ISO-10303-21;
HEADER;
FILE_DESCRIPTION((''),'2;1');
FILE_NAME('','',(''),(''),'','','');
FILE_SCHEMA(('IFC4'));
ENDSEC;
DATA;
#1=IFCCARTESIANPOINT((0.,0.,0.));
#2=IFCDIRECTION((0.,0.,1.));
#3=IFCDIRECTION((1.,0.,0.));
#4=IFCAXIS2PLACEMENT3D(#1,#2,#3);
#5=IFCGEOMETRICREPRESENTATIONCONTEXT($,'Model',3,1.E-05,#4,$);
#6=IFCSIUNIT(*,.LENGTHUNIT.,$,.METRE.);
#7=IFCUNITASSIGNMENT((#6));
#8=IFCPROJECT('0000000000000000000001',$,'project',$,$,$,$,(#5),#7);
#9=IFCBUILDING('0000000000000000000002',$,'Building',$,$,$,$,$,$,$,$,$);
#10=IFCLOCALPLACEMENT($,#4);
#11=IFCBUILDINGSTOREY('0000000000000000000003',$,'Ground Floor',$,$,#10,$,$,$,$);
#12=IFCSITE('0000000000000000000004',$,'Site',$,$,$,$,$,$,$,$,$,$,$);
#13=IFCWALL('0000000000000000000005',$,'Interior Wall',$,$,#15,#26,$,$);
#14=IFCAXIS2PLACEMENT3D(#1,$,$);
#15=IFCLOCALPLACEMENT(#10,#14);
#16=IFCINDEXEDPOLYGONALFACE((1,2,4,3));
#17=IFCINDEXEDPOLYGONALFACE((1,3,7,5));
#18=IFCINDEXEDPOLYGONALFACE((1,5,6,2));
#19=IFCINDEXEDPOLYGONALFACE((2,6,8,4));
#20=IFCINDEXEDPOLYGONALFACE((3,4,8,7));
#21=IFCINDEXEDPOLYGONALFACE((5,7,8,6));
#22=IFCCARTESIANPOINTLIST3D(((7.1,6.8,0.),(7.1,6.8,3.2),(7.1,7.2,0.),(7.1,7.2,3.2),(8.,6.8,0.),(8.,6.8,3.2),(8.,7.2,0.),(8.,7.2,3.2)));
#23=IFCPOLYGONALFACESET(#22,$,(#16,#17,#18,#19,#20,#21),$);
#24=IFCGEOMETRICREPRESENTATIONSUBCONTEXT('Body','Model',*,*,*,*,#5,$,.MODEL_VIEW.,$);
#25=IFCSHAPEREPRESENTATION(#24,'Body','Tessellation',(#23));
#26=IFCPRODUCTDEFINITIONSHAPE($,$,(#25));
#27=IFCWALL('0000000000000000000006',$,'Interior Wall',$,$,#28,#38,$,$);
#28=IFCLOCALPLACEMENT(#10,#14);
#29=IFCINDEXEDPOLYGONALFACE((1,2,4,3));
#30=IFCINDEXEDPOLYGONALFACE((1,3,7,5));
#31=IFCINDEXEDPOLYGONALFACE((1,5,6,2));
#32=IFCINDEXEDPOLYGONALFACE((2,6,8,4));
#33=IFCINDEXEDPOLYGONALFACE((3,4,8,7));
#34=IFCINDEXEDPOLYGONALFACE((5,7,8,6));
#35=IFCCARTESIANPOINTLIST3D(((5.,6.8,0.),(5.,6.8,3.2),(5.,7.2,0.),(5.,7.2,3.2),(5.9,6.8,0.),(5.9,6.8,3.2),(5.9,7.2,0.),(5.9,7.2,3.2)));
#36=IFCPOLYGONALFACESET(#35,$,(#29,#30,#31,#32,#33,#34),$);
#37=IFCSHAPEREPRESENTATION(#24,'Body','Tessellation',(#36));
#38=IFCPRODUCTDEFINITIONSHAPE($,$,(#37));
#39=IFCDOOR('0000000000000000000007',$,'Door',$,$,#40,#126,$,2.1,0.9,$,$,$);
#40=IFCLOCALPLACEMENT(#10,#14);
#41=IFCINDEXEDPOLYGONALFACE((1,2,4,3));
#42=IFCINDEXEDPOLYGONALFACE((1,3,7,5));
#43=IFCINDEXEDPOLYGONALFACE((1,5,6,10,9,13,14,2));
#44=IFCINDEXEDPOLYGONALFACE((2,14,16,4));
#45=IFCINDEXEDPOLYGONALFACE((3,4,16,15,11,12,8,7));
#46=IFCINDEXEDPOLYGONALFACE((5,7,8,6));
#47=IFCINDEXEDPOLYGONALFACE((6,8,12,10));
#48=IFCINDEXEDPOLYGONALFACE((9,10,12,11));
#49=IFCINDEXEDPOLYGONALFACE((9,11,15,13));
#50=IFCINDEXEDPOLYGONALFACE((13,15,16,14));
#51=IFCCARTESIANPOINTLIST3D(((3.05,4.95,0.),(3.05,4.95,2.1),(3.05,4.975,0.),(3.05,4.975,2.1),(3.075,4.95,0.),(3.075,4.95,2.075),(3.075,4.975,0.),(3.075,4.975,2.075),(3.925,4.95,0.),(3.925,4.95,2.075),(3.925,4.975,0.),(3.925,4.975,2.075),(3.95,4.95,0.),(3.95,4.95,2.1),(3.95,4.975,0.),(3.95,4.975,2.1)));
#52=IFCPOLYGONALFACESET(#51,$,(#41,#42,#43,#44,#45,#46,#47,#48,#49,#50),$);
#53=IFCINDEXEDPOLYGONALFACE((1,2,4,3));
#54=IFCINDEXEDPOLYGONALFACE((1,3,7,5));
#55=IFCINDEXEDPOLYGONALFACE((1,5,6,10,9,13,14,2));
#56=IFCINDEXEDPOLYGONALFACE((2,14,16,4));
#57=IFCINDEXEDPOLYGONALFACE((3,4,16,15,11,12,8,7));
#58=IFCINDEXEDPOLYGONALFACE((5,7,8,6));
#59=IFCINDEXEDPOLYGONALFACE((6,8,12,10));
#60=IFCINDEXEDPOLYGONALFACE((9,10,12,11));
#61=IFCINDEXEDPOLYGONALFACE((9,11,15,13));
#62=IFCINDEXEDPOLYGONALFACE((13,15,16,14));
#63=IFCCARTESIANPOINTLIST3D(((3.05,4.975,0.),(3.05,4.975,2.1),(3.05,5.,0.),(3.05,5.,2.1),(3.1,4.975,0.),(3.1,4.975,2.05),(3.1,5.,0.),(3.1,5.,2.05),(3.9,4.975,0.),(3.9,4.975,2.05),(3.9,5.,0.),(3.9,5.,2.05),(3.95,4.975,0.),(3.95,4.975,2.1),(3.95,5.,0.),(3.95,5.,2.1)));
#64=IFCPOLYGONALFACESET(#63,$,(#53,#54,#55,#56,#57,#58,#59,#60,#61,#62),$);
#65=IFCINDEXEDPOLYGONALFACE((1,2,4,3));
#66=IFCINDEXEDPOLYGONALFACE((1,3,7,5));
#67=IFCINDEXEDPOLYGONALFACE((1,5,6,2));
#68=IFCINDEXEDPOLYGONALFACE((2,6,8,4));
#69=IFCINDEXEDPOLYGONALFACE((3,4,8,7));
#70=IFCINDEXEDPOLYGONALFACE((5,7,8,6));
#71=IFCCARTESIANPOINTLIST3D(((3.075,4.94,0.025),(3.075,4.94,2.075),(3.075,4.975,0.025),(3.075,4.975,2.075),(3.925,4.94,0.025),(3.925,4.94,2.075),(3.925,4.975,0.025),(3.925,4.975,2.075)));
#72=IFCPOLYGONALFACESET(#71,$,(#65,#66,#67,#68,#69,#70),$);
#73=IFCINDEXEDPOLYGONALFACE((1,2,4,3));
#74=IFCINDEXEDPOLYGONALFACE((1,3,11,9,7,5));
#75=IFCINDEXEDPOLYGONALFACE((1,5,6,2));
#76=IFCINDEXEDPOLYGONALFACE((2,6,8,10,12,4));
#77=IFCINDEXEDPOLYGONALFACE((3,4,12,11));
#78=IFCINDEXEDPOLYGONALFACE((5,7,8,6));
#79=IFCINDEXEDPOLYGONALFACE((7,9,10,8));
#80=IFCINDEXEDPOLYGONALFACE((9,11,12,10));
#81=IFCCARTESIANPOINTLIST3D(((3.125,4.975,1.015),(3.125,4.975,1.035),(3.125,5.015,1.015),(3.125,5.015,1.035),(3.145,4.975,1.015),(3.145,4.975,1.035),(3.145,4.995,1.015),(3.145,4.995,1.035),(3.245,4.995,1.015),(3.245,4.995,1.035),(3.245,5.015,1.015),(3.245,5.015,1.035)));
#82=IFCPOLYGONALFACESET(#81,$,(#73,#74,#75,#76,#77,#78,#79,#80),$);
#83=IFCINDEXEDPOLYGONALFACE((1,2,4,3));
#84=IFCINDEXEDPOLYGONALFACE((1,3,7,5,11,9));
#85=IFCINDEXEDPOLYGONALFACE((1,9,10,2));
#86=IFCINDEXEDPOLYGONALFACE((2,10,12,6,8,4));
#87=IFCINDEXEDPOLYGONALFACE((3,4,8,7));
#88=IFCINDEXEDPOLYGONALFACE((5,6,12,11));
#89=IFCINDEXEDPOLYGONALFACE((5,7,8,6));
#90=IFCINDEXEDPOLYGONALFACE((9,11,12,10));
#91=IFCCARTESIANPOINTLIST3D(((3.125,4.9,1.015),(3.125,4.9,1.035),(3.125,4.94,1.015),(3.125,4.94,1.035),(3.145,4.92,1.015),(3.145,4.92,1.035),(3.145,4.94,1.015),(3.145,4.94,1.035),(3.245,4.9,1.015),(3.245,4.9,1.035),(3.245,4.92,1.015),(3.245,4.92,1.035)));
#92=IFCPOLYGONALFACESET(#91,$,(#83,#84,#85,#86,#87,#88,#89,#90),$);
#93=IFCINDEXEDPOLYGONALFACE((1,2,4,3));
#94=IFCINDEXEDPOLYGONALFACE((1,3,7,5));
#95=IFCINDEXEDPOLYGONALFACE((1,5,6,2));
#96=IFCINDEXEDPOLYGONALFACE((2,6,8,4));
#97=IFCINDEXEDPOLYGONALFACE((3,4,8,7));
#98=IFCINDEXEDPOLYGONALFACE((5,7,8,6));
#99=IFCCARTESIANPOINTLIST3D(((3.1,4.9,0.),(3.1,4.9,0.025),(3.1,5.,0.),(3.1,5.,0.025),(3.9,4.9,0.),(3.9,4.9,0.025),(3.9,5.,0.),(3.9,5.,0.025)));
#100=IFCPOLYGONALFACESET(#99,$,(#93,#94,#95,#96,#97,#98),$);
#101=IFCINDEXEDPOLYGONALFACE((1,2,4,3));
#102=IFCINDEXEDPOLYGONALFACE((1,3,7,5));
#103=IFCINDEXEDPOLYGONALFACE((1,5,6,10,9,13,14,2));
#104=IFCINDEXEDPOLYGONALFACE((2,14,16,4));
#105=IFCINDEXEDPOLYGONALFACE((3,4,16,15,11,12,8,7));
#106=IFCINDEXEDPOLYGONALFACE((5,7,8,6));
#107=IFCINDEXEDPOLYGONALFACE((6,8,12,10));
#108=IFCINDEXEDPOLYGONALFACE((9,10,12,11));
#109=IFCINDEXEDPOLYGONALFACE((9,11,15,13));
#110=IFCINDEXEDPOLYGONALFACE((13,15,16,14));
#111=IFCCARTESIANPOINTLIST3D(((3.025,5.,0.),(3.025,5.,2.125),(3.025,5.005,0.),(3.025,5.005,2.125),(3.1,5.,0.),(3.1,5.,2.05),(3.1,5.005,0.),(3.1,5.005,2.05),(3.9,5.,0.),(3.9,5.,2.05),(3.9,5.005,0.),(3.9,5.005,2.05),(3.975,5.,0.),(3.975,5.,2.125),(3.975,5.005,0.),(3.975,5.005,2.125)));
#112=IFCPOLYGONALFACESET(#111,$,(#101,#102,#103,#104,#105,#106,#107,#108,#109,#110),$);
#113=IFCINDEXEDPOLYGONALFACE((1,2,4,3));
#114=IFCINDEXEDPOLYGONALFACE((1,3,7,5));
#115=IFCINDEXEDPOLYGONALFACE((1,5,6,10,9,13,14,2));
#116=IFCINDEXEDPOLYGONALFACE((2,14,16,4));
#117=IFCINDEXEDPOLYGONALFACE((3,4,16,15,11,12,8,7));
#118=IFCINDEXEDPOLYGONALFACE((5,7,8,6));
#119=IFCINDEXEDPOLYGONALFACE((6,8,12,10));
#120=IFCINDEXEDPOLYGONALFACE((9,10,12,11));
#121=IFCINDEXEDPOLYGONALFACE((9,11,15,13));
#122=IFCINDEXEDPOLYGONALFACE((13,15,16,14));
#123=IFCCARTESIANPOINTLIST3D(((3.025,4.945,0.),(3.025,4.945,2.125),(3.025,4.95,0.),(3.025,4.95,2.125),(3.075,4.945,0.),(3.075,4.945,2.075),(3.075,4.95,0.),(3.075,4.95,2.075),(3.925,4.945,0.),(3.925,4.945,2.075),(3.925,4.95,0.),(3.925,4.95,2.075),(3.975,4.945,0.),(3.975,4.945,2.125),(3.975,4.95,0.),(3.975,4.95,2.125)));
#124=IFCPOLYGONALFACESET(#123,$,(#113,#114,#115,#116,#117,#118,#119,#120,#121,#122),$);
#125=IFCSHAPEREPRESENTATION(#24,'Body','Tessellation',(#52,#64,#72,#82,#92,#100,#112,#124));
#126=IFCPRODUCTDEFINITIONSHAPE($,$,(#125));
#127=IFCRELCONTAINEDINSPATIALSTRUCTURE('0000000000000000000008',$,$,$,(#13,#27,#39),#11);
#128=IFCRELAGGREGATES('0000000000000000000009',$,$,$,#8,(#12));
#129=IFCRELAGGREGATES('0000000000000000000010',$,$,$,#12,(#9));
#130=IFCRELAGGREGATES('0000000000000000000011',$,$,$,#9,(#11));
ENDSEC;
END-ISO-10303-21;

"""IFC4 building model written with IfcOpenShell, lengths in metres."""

from ifc_helpers import new_model, si_unit, frame, origin_with_axes, place, context, subcontext, project, spatial, line, indexed_curve, outline, extrude, element, save


model = new_model("IFC4")

# Units and contexts
model_context = context("Model", 3, precision=1e-05, world=origin_with_axes())
body_context = subcontext(model_context, "Body", "Model", "MODEL_VIEW")
ifc_project = project(units=[si_unit("LENGTHUNIT", "METRE")], contexts=[model_context])

# Site, building, storey
site = spatial("IfcSite", under=ifc_project, Name="Site")
building = spatial("IfcBuilding", under=site, Name="Building")
storey_placement = place(None, origin_with_axes())
storey = spatial("IfcBuildingStorey", under=building, at=storey_placement, Name="Ground Floor")

# Walls
for number, where, z_axis, x_axis, name in (
    (1, (8.0, 7.0, 0.0), (0.0, 0.0, 1.0), (-1.0, 0.0, 0.0), "Interior Wall"),
    (2, (5.9, 7.0, 0.0), (0.0, 0.0, 1.0), (-1.0, 0.0, 0.0), "Interior Wall"),
):
    element("IfcWall", number, at=place(storey_placement, frame(where, z_axis=z_axis, x_axis=x_axis)), inside=storey, Name=name, context=body_context, shape_type="SweptSolid", body=[
        extrude(outline(indexed_curve([(0.0, 0.0), (0.0, 0.4), (0.9, 0.4), (0.9, 0.0), (0.0, 0.0)], self_intersect=False)), frame((0.0, -0.2, 0.0), z_axis=(0.0, 0.0, 1.0), x_axis=(1.0, 0.0, 0.0)), (0.0, 0.0, 1.0), 3.2),
    ])

# Door
door_1_placement = place(storey_placement, frame((3.95, 5.0, 0.0), z_axis=(0.0, 0.0, 1.0), x_axis=(-1.0, 0.0, 0.0)))
element("IfcDoor", 3, at=door_1_placement, inside=storey, Name="Door", OverallHeight=2.1, OverallWidth=0.9, context=body_context, shape_type="SweptSolid", body=[
    extrude(outline(indexed_curve([(0.0, 0.0), (0.0, 2.1), (0.9, 2.1), (0.9, 0.0), (0.875, 0.0), (0.875, 2.075), (0.025, 2.075), (0.025, 0.0)], segments=[line(1, 2, 3, 4, 5, 6, 7, 8, 1)])), frame((0.0, 0.025, 0.0), z_axis=(0.0, -1.0, 0.0), x_axis=(1.0, 0.0, 0.0)), (0.0, 0.0, -1.0), 0.025),
    extrude(outline(indexed_curve([(0.0, 0.0), (0.0, 2.1), (0.9, 2.1), (0.9, 0.0), (0.85, 0.0), (0.85, 2.05), (0.05, 2.05), (0.05, 0.0)], segments=[line(1, 2, 3, 4, 5, 6, 7, 8, 1)])), frame((0.0, 0.0, 0.0), z_axis=(0.0, -1.0, 0.0), x_axis=(1.0, 0.0, 0.0)), (0.0, 0.0, -1.0), 0.025),
    extrude(outline(indexed_curve([(0.0, 0.0), (0.85, 0.0), (0.85, 0.035), (0.0, 0.035)], segments=[line(1, 2, 3, 4, 1)])), frame((0.025, 0.025, 0.025), z_axis=(0.0, 0.0, 1.0), x_axis=(1.0, 0.0, 0.0)), (0.0, 0.0, 1.0), 2.05),
    extrude(outline(indexed_curve([(0.0, 0.0), (0.0, -0.04), (-0.12, -0.04), (-0.12, -0.02), (-0.02, -0.02), (-0.02, 0.0)], segments=[line(1, 2, 3, 4, 5, 6, 1)])), frame((0.825, 0.025, 1.015), z_axis=(0.0, 0.0, 1.0), x_axis=(1.0, 0.0, 0.0)), (0.0, 0.0, 1.0), 0.02),
    extrude(outline(indexed_curve([(0.0, 0.0), (0.0, 0.04), (-0.12, 0.04), (-0.12, 0.02), (-0.02, 0.02), (-0.02, 0.0)], segments=[line(1, 2, 3, 4, 5, 6, 1)])), frame((0.825, 0.06, 1.015), z_axis=(0.0, 0.0, 1.0), x_axis=(1.0, 0.0, 0.0)), (0.0, 0.0, 1.0), 0.02),
    extrude(outline(indexed_curve([(0.0, 0.0), (0.8, 0.0), (0.8, 0.1), (0.0, 0.1)], segments=[line(1, 2, 3, 4, 1)])), frame((0.05, 0.0, 0.0), z_axis=(0.0, 0.0, 1.0), x_axis=(1.0, 0.0, 0.0)), (0.0, 0.0, 1.0), 0.025),
    extrude(outline(indexed_curve([(0.0, 0.0), (0.0, 2.125), (0.95, 2.125), (0.95, 0.0), (0.875, 0.0), (0.875, 2.05), (0.075, 2.05), (0.075, 0.0)], segments=[line(1, 2, 3, 4, 5, 6, 7, 8, 1)])), frame((-0.025, -0.005, 0.0), z_axis=(0.0, -1.0, 0.0), x_axis=(1.0, 0.0, 0.0)), (0.0, 0.0, -1.0), 0.005),
    extrude(outline(indexed_curve([(0.0, 0.0), (0.0, 2.125), (0.95, 2.125), (0.95, 0.0), (0.9, 0.0), (0.9, 2.075), (0.05, 2.075), (0.05, 0.0)], segments=[line(1, 2, 3, 4, 5, 6, 7, 8, 1)])), frame((-0.025, 0.05, 0.0), z_axis=(0.0, -1.0, 0.0), x_axis=(1.0, 0.0, 0.0)), (0.0, 0.0, -1.0), 0.005),
])

save(model, "model.ifc")
